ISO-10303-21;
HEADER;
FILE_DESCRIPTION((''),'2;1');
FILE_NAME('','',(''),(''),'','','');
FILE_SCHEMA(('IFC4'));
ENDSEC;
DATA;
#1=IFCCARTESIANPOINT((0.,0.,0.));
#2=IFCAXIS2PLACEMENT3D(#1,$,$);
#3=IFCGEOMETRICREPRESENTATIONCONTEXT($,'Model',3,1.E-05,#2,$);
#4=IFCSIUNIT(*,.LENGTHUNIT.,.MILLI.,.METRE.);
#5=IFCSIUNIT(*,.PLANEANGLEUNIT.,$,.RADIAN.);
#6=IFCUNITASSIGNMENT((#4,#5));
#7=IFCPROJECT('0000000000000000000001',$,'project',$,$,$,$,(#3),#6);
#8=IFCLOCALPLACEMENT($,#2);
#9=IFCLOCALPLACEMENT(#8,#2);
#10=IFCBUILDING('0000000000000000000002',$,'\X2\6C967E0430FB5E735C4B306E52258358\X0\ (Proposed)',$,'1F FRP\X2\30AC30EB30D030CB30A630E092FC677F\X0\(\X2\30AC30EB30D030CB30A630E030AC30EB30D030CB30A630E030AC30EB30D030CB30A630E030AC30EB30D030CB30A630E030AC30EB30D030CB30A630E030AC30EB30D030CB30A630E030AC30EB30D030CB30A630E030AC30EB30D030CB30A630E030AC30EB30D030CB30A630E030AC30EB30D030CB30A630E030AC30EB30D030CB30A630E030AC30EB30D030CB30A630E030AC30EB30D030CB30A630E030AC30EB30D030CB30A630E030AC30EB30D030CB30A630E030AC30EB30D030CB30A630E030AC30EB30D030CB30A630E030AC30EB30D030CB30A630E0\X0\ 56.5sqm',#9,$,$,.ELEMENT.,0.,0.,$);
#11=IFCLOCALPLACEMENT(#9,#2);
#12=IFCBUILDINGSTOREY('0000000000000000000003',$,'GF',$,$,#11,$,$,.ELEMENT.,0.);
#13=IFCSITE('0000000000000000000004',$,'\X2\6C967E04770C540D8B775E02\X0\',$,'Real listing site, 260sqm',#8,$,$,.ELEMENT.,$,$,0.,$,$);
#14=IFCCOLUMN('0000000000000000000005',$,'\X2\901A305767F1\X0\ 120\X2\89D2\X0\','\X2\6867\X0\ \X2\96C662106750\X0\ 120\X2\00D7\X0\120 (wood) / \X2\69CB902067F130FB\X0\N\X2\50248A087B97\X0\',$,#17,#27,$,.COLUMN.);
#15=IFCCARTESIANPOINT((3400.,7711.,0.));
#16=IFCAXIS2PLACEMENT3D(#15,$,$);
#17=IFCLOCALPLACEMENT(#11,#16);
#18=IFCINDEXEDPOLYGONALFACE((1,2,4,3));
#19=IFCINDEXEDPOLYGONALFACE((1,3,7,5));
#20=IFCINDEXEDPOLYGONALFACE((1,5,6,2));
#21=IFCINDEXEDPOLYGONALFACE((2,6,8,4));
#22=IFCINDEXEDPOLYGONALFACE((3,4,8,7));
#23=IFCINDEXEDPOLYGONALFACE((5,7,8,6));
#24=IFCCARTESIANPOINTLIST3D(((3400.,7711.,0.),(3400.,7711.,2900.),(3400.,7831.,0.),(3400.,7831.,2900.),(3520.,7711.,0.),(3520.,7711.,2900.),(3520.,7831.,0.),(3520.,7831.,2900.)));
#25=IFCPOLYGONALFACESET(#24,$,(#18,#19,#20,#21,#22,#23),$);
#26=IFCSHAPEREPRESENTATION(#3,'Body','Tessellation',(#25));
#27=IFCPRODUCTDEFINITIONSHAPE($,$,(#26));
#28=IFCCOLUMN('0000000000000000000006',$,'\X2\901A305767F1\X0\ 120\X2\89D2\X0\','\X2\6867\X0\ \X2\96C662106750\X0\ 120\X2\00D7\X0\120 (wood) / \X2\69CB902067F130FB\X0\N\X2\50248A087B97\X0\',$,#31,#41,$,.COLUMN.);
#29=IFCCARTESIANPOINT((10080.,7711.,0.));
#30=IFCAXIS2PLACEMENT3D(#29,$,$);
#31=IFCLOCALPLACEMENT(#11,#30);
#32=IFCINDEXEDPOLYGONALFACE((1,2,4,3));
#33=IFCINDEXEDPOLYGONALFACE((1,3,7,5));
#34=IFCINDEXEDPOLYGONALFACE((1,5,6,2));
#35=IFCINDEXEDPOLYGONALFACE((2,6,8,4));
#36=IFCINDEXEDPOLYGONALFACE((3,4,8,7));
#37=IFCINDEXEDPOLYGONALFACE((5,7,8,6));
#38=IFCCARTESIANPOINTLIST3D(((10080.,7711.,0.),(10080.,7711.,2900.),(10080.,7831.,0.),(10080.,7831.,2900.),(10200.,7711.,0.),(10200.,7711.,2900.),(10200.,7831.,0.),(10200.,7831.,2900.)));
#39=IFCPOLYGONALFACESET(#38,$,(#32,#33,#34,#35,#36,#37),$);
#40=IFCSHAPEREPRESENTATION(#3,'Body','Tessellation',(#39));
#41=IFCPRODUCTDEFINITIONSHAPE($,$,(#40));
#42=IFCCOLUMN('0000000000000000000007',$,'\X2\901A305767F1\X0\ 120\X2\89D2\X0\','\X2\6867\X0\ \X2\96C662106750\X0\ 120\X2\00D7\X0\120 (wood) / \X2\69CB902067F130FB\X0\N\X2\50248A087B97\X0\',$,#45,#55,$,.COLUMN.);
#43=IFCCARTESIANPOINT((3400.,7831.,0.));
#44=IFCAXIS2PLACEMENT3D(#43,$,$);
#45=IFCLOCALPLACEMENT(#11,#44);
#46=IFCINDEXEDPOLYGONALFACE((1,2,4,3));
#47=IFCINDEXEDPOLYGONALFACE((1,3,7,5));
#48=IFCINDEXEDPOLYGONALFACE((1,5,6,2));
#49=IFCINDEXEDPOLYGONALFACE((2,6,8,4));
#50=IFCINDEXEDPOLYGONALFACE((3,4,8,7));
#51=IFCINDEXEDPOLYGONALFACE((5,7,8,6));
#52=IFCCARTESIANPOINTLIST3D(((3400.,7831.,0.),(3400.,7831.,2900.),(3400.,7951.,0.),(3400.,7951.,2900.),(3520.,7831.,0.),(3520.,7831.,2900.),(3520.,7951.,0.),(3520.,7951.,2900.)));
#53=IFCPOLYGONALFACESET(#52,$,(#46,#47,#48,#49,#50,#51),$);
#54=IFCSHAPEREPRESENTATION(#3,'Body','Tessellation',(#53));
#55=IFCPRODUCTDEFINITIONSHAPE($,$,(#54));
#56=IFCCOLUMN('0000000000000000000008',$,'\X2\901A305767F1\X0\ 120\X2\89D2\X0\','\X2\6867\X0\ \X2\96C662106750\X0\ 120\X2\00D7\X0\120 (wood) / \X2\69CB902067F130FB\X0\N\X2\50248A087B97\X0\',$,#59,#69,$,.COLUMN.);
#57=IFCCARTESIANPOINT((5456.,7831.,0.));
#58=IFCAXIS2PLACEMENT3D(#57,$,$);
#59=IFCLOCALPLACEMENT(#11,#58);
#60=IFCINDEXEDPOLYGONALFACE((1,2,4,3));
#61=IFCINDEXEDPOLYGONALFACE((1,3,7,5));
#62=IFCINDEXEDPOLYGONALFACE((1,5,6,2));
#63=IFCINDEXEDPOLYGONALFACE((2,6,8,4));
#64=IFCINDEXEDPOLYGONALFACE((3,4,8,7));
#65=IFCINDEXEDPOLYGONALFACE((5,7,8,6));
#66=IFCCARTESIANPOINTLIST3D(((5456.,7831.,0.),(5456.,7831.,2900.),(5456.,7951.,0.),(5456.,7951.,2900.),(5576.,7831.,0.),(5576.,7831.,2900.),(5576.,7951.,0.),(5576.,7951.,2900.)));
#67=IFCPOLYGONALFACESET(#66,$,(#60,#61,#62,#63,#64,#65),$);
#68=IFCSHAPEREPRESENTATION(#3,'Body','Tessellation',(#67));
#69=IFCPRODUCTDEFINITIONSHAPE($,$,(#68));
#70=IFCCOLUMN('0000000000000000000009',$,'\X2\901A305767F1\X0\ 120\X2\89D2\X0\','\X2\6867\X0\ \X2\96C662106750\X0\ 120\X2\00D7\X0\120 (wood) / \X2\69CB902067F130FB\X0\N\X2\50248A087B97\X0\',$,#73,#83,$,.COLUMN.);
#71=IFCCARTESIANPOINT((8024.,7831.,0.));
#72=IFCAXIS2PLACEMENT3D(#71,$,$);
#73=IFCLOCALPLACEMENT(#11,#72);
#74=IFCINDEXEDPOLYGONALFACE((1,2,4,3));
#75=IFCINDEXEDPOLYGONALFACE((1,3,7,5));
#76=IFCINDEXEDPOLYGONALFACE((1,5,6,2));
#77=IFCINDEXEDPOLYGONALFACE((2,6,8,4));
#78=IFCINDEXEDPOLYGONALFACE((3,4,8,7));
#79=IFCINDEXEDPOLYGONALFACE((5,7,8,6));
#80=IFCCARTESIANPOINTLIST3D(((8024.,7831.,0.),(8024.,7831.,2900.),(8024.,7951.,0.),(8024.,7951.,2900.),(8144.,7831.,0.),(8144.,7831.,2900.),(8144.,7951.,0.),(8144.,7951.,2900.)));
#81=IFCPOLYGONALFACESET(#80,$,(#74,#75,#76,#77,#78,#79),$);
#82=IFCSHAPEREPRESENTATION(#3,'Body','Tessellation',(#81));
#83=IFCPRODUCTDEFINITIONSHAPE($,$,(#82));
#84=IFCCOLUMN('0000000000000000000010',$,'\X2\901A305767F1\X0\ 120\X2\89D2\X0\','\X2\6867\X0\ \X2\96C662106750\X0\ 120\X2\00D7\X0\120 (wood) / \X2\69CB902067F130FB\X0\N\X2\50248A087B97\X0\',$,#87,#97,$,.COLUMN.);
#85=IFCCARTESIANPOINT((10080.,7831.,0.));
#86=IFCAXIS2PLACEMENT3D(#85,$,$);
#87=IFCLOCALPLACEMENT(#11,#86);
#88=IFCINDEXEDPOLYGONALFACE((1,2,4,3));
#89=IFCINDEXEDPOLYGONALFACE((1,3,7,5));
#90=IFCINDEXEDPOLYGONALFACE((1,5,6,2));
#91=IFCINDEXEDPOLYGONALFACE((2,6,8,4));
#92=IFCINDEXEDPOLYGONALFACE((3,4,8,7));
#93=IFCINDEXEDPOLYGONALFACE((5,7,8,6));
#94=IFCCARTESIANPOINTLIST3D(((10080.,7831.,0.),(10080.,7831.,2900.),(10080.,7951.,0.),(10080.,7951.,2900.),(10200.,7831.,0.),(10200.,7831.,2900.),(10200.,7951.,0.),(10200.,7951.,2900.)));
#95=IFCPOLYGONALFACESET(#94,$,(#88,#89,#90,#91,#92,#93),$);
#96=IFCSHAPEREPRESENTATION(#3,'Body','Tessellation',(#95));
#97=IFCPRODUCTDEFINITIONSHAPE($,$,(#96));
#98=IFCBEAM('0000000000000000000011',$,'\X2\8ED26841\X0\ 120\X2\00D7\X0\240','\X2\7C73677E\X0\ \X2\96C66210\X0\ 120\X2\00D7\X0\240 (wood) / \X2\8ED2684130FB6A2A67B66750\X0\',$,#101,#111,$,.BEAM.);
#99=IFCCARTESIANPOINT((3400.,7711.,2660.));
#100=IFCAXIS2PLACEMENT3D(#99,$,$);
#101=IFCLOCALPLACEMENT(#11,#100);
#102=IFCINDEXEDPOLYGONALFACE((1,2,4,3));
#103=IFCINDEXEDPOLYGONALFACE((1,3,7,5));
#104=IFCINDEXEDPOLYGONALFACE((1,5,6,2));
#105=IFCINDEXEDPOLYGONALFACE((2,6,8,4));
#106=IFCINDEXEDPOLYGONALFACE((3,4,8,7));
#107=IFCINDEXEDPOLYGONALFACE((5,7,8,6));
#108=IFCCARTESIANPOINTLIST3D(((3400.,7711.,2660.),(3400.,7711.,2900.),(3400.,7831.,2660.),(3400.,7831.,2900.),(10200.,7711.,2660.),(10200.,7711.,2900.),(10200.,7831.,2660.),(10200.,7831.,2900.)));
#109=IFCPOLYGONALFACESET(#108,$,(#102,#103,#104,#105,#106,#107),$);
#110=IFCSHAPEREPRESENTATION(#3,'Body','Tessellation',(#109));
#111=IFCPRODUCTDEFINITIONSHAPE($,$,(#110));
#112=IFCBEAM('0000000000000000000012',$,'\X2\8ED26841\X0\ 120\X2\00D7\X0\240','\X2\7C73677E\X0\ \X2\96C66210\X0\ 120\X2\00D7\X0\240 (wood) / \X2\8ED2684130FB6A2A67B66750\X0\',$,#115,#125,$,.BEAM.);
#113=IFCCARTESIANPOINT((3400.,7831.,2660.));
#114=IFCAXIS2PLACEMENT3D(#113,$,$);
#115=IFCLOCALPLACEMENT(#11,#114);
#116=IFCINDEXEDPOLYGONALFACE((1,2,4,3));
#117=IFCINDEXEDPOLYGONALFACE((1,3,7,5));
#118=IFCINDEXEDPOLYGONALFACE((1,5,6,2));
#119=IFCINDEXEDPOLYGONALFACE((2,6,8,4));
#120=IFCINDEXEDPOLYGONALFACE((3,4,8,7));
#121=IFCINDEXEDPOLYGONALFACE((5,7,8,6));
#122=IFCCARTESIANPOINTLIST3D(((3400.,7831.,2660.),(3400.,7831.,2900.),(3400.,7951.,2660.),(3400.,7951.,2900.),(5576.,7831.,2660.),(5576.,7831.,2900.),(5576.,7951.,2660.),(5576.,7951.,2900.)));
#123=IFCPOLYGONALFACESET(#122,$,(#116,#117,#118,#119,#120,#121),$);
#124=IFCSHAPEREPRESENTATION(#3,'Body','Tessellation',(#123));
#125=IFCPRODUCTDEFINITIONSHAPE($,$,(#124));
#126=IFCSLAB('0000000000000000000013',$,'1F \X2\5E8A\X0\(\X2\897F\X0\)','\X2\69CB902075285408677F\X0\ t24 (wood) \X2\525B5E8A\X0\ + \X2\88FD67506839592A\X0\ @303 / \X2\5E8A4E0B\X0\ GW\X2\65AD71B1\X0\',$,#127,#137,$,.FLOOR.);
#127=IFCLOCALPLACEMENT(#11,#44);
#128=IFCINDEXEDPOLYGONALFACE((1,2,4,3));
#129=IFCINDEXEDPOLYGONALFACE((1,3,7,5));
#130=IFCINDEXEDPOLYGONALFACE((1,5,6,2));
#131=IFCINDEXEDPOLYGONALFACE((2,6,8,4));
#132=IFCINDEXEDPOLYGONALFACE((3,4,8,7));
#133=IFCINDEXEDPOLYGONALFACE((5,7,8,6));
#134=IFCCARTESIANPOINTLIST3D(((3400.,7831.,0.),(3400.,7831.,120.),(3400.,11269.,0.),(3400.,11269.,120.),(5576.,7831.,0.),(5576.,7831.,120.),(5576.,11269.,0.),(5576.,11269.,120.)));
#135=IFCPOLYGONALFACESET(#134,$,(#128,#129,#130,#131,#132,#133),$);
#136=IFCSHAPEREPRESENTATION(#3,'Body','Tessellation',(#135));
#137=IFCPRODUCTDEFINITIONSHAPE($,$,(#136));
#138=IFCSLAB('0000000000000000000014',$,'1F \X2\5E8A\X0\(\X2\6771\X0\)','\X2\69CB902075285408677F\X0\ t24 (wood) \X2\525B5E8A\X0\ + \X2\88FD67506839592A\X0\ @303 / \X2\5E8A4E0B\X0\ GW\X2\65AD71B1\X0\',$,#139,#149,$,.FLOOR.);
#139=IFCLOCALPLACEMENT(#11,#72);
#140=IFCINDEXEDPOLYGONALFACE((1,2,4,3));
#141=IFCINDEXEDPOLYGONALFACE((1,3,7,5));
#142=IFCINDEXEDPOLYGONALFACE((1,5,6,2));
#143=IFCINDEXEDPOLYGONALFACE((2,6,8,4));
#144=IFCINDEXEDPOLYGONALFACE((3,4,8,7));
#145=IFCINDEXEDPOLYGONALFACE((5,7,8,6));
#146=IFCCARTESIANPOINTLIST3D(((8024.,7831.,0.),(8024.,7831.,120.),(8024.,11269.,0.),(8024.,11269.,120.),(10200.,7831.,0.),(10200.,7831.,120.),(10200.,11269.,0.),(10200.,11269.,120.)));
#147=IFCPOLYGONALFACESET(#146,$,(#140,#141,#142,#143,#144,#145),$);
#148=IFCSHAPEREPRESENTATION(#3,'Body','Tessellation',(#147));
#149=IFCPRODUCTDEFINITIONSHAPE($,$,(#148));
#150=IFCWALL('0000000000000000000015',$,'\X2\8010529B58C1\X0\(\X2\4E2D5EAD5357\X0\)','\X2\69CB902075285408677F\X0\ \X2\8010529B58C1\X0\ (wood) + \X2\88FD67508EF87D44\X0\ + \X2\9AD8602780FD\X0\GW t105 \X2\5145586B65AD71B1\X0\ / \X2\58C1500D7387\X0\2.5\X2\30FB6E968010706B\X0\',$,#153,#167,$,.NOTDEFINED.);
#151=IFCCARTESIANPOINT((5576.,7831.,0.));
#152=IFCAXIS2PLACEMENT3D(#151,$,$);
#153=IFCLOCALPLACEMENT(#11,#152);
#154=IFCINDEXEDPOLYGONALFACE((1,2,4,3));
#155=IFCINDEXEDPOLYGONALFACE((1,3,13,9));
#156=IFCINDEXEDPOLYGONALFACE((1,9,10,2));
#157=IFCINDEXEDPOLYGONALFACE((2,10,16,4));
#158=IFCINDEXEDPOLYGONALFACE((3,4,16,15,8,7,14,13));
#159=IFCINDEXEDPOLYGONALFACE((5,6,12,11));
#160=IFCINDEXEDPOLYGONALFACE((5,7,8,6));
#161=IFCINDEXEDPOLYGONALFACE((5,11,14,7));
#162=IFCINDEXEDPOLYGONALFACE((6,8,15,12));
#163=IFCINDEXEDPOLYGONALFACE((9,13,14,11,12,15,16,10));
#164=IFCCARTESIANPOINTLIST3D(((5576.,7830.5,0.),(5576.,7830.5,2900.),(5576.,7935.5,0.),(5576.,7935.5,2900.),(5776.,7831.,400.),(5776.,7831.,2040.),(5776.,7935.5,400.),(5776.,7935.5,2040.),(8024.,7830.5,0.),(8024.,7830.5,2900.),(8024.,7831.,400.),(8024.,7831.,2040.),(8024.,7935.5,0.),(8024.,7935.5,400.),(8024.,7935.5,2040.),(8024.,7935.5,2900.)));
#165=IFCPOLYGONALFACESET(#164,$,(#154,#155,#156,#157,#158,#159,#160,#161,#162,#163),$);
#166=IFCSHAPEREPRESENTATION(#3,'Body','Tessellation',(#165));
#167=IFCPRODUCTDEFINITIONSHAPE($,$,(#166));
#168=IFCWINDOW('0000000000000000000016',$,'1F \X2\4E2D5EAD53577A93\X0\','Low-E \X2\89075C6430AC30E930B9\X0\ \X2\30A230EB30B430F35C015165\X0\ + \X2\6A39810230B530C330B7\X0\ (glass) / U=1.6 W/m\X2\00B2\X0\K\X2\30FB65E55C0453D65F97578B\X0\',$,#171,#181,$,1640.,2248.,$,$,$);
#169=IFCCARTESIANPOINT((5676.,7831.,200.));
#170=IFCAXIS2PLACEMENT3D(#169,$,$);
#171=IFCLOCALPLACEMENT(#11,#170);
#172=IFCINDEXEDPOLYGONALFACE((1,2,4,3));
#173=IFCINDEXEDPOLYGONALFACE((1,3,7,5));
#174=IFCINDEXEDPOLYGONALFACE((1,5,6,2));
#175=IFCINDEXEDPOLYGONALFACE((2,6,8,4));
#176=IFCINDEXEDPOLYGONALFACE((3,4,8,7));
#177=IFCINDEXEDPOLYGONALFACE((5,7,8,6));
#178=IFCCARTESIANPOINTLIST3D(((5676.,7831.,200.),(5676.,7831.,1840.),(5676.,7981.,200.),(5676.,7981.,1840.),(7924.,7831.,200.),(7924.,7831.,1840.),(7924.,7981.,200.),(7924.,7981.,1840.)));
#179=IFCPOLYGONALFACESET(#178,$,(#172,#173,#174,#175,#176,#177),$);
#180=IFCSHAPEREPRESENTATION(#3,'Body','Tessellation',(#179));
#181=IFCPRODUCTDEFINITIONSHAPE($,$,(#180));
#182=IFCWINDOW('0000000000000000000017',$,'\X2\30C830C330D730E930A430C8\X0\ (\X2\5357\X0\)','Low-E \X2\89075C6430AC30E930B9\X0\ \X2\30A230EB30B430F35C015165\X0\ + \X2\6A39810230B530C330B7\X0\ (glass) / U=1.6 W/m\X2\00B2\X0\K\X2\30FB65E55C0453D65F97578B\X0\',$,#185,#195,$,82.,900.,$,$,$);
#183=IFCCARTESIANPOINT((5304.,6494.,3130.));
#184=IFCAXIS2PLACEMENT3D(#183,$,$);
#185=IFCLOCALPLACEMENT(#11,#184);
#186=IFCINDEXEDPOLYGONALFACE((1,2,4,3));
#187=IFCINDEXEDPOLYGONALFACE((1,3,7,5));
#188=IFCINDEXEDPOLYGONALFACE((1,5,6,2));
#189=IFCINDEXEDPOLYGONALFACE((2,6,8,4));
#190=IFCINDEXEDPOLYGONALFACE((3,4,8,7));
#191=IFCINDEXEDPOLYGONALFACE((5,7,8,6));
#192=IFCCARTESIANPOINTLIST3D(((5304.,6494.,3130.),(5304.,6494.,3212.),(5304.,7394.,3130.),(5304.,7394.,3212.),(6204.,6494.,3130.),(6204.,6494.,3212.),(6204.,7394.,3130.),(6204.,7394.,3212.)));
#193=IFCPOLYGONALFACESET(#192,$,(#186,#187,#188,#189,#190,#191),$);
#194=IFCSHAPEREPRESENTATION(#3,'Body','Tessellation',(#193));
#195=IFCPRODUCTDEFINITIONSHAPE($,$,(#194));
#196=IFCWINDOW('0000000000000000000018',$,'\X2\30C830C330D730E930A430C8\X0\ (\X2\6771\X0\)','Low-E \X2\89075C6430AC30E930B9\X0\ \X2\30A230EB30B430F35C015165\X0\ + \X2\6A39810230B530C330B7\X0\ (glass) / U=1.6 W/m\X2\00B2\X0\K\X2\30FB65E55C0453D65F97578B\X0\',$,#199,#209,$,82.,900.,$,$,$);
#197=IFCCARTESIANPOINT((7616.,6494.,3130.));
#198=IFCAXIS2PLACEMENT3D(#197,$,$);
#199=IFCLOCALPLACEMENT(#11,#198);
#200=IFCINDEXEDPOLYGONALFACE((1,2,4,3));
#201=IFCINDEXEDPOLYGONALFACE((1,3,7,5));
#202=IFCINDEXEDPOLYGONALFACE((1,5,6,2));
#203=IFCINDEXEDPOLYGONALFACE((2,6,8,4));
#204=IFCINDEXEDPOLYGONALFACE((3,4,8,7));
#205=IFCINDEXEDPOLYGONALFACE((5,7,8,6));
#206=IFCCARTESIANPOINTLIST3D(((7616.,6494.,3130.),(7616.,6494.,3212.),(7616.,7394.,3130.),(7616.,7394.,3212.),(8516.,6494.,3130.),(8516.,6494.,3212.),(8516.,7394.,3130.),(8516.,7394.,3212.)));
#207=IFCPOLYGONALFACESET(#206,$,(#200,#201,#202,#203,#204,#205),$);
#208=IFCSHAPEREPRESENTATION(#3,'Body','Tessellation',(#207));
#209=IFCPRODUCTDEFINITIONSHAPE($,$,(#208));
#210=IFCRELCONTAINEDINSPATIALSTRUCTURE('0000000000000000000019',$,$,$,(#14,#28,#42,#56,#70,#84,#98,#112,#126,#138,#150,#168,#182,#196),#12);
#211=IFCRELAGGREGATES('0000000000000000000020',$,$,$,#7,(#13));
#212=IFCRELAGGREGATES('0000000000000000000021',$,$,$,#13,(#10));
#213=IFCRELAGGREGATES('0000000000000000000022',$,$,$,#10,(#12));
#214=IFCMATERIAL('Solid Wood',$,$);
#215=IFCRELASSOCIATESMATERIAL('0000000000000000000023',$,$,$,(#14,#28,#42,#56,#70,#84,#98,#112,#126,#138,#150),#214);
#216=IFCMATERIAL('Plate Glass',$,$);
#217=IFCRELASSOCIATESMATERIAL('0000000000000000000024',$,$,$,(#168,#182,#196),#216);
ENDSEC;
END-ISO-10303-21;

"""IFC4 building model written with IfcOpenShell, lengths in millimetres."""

from ifc_helpers import new_model, si_unit, frame, frame_2d, origin, place, context, project, spatial, rectangle, extrude, material, element, fill, save


model = new_model("IFC4")

# Units and contexts
model_context = context("Model", 3, precision=1e-05, world=origin())
ifc_project = project(units=[si_unit("LENGTHUNIT", "METRE", prefix="MILLI"), si_unit("PLANEANGLEUNIT", "RADIAN")], contexts=[model_context])

# Site, building, storey
site_placement = place(None, origin())
site = spatial("IfcSite", under=ifc_project, at=site_placement, Name="沖縄県名護市", ObjectType="Real listing site, 260sqm", CompositionType="ELEMENT", RefElevation=0.0)
building_placement = place(site_placement, origin())
building = spatial("IfcBuilding", under=site, at=building_placement, Name="沖縄・平屋の別荘 (Proposed)", ObjectType="1F FRPガルバニウム鋼板(ガルバニウムガルバニウムガルバニウムガルバニウムガルバニウムガルバニウムガルバニウムガルバニウムガルバニウムガルバニウムガルバニウムガルバニウムガルバニウムガルバニウムガルバニウムガルバニウムガルバニウムガルバニウム 56.5sqm", CompositionType="ELEMENT", ElevationOfRefHeight=0.0, ElevationOfTerrain=0.0)
storey_placement = place(building_placement, origin())
storey = spatial("IfcBuildingStorey", under=building, at=storey_placement, Name="GF", CompositionType="ELEMENT", Elevation=0.0)

# Columns
ifc_material_1 = material(Name="Solid Wood")
column_1_placement = place(storey_placement, frame((3400.0, 7711.0, 0.0)))
element("IfcColumn", 1, at=column_1_placement, inside=storey, material=ifc_material_1, Name="通し柱 120角", Description="桧 集成材 120×120 (wood) / 構造柱・N値計算", PredefinedType="COLUMN", context=model_context, shape_type="SweptSolid", body=[
    extrude(rectangle(XDim=120.0, YDim=120.0, at=frame_2d((60.0, 60.0))), frame((3400.0, 7711.0, 0.0)), (0.0, 0.0, 1.0), 2900.0),
])
column_2_placement = place(storey_placement, frame((10080.0, 7711.0, 0.0)))
element("IfcColumn", 2, at=column_2_placement, inside=storey, material=ifc_material_1, Name="通し柱 120角", Description="桧 集成材 120×120 (wood) / 構造柱・N値計算", PredefinedType="COLUMN", context=model_context, shape_type="SweptSolid", body=[
    extrude(rectangle(XDim=120.0, YDim=120.0, at=frame_2d((60.0, 60.0))), frame((10080.0, 7711.0, 0.0)), (0.0, 0.0, 1.0), 2900.0),
])
column_3_placement = place(storey_placement, frame((3400.0, 7831.0, 0.0)))
element("IfcColumn", 3, at=column_3_placement, inside=storey, material=ifc_material_1, Name="通し柱 120角", Description="桧 集成材 120×120 (wood) / 構造柱・N値計算", PredefinedType="COLUMN", context=model_context, shape_type="SweptSolid", body=[
    extrude(rectangle(XDim=120.0, YDim=120.0, at=frame_2d((60.0, 60.0))), frame((3400.0, 7831.0, 0.0)), (0.0, 0.0, 1.0), 2900.0),
])
column_4_placement = place(storey_placement, frame((5456.0, 7831.0, 0.0)))
element("IfcColumn", 4, at=column_4_placement, inside=storey, material=ifc_material_1, Name="通し柱 120角", Description="桧 集成材 120×120 (wood) / 構造柱・N値計算", PredefinedType="COLUMN", context=model_context, shape_type="SweptSolid", body=[
    extrude(rectangle(XDim=120.0, YDim=120.0, at=frame_2d((60.0, 60.0))), frame((5456.0, 7831.0, 0.0)), (0.0, 0.0, 1.0), 2900.0),
])
column_5_placement = place(storey_placement, frame((8024.0, 7831.0, 0.0)))
element("IfcColumn", 5, at=column_5_placement, inside=storey, material=ifc_material_1, Name="通し柱 120角", Description="桧 集成材 120×120 (wood) / 構造柱・N値計算", PredefinedType="COLUMN", context=model_context, shape_type="SweptSolid", body=[
    extrude(rectangle(XDim=120.0, YDim=120.0, at=frame_2d((60.0, 60.0))), frame((8024.0, 7831.0, 0.0)), (0.0, 0.0, 1.0), 2900.0),
])
column_6_placement = place(storey_placement, frame((10080.0, 7831.0, 0.0)))
element("IfcColumn", 6, at=column_6_placement, inside=storey, material=ifc_material_1, Name="通し柱 120角", Description="桧 集成材 120×120 (wood) / 構造柱・N値計算", PredefinedType="COLUMN", context=model_context, shape_type="SweptSolid", body=[
    extrude(rectangle(XDim=120.0, YDim=120.0, at=frame_2d((60.0, 60.0))), frame((10080.0, 7831.0, 0.0)), (0.0, 0.0, 1.0), 2900.0),
])

# Beams
beam_1_placement = place(storey_placement, frame((3400.0, 7711.0, 2660.0)))
element("IfcBeam", 7, at=beam_1_placement, inside=storey, material=ifc_material_1, Name="軒桁 120×240", Description="米松 集成 120×240 (wood) / 軒桁・横架材", PredefinedType="BEAM", context=model_context, shape_type="SweptSolid", body=[
    extrude(rectangle(XDim=6800.0, YDim=120.0, at=frame_2d((3400.0, 60.0))), frame((3400.0, 7711.0, 2660.0)), (0.0, 0.0, 1.0), 240.0),
])
beam_2_placement = place(storey_placement, frame((3400.0, 7831.0, 2660.0)))
element("IfcBeam", 8, at=beam_2_placement, inside=storey, material=ifc_material_1, Name="軒桁 120×240", Description="米松 集成 120×240 (wood) / 軒桁・横架材", PredefinedType="BEAM", context=model_context, shape_type="SweptSolid", body=[
    extrude(rectangle(XDim=2176.0, YDim=120.0, at=frame_2d((1088.0, 60.0))), frame((3400.0, 7831.0, 2660.0)), (0.0, 0.0, 1.0), 240.0),
])

# Slabs
slab_1_placement = place(storey_placement, frame((3400.0, 7831.0, 0.0)))
element("IfcSlab", 9, at=slab_1_placement, inside=storey, material=ifc_material_1, Name="1F 床(西)", Description="構造用合板 t24 (wood) 剛床 + 製材根太 @303 / 床下 GW断熱", PredefinedType="FLOOR", context=model_context, shape_type="SweptSolid", body=[
    extrude(rectangle(XDim=2176.0, YDim=3438.0, at=frame_2d((1088.0, 1719.0))), frame((3400.0, 7831.0, 0.0)), (0.0, 0.0, 1.0), 120.0),
])
slab_2_placement = place(storey_placement, frame((8024.0, 7831.0, 0.0)))
element("IfcSlab", 10, at=slab_2_placement, inside=storey, material=ifc_material_1, Name="1F 床(東)", Description="構造用合板 t24 (wood) 剛床 + 製材根太 @303 / 床下 GW断熱", PredefinedType="FLOOR", context=model_context, shape_type="SweptSolid", body=[
    extrude(rectangle(XDim=2176.0, YDim=3438.0, at=frame_2d((1088.0, 1719.0))), frame((8024.0, 7831.0, 0.0)), (0.0, 0.0, 1.0), 120.0),
])

# Wall, opening, window
wall_1_placement = place(storey_placement, frame((5576.0, 7831.0, 0.0)))
wall_1 = element("IfcWall", 11, at=wall_1_placement, inside=storey, material=ifc_material_1, Name="耐力壁(中庭南)", Description="構造用合板 耐力壁 (wood) + 製材軸組 + 高性能GW t105 充填断熱 / 壁倍率2.5・準耐火", PredefinedType="NOTDEFINED", context=model_context, shape_type="SweptSolid", body=[
    extrude(rectangle(XDim=2448.0, YDim=105.0, at=frame_2d((1224.0, 52.0))), frame((5576.0, 7831.0, 0.0)), (0.0, 0.0, 1.0), 2900.0),
])
opening_placement = place(storey_placement, frame((5676.0, 7831.0, 200.0)))
opening = element("IfcOpeningElement", 12, at=opening_placement, cuts=wall_1, PredefinedType="NOTDEFINED", context=model_context, shape_type="SweptSolid", body=[
    extrude(rectangle(XDim=2248.0, YDim=150.0, at=frame_2d((1124.0, 75.0))), frame((5676.0, 7831.0, 200.0)), (0.0, 0.0, 1.0), 1640.0),
])
ifc_material_2 = material(Name="Plate Glass")
window_1_placement = place(storey_placement, frame((5676.0, 7831.0, 200.0)))
window_1 = element("IfcWindow", 13, at=window_1_placement, inside=storey, material=ifc_material_2, Name="1F 中庭南窓", Description="Low-E 複層ガラス アルゴン封入 + 樹脂サッシ (glass) / U=1.6 W/m²K・日射取得型", OverallHeight=1640.0, OverallWidth=2248.0, context=model_context, shape_type="SweptSolid", body=[
    extrude(rectangle(XDim=2248.0, YDim=150.0, at=frame_2d((1124.0, 75.0))), frame((5676.0, 7831.0, 200.0)), (0.0, 0.0, 1.0), 1640.0),
])
fill(opening, window_1)

# Windows
window_2_placement = place(storey_placement, frame((5304.0, 6494.0, 3130.0)))
element("IfcWindow", 14, at=window_2_placement, inside=storey, material=ifc_material_2, Name="トップライト (南)", Description="Low-E 複層ガラス アルゴン封入 + 樹脂サッシ (glass) / U=1.6 W/m²K・日射取得型", OverallHeight=82.0, OverallWidth=900.0, context=model_context, shape_type="SweptSolid", body=[
    extrude(rectangle(XDim=900.0, YDim=900.0, at=frame_2d((450.0, 450.0))), frame((5304.0, 6494.0, 3130.0)), (0.0, 0.0, 1.0), 82.0),
])
window_3_placement = place(storey_placement, frame((7616.0, 6494.0, 3130.0)))
element("IfcWindow", 15, at=window_3_placement, inside=storey, material=ifc_material_2, Name="トップライト (東)", Description="Low-E 複層ガラス アルゴン封入 + 樹脂サッシ (glass) / U=1.6 W/m²K・日射取得型", OverallHeight=82.0, OverallWidth=900.0, context=model_context, shape_type="SweptSolid", body=[
    extrude(rectangle(XDim=900.0, YDim=900.0, at=frame_2d((450.0, 450.0))), frame((7616.0, 6494.0, 3130.0)), (0.0, 0.0, 1.0), 82.0),
])

save(model, "model.ifc")
